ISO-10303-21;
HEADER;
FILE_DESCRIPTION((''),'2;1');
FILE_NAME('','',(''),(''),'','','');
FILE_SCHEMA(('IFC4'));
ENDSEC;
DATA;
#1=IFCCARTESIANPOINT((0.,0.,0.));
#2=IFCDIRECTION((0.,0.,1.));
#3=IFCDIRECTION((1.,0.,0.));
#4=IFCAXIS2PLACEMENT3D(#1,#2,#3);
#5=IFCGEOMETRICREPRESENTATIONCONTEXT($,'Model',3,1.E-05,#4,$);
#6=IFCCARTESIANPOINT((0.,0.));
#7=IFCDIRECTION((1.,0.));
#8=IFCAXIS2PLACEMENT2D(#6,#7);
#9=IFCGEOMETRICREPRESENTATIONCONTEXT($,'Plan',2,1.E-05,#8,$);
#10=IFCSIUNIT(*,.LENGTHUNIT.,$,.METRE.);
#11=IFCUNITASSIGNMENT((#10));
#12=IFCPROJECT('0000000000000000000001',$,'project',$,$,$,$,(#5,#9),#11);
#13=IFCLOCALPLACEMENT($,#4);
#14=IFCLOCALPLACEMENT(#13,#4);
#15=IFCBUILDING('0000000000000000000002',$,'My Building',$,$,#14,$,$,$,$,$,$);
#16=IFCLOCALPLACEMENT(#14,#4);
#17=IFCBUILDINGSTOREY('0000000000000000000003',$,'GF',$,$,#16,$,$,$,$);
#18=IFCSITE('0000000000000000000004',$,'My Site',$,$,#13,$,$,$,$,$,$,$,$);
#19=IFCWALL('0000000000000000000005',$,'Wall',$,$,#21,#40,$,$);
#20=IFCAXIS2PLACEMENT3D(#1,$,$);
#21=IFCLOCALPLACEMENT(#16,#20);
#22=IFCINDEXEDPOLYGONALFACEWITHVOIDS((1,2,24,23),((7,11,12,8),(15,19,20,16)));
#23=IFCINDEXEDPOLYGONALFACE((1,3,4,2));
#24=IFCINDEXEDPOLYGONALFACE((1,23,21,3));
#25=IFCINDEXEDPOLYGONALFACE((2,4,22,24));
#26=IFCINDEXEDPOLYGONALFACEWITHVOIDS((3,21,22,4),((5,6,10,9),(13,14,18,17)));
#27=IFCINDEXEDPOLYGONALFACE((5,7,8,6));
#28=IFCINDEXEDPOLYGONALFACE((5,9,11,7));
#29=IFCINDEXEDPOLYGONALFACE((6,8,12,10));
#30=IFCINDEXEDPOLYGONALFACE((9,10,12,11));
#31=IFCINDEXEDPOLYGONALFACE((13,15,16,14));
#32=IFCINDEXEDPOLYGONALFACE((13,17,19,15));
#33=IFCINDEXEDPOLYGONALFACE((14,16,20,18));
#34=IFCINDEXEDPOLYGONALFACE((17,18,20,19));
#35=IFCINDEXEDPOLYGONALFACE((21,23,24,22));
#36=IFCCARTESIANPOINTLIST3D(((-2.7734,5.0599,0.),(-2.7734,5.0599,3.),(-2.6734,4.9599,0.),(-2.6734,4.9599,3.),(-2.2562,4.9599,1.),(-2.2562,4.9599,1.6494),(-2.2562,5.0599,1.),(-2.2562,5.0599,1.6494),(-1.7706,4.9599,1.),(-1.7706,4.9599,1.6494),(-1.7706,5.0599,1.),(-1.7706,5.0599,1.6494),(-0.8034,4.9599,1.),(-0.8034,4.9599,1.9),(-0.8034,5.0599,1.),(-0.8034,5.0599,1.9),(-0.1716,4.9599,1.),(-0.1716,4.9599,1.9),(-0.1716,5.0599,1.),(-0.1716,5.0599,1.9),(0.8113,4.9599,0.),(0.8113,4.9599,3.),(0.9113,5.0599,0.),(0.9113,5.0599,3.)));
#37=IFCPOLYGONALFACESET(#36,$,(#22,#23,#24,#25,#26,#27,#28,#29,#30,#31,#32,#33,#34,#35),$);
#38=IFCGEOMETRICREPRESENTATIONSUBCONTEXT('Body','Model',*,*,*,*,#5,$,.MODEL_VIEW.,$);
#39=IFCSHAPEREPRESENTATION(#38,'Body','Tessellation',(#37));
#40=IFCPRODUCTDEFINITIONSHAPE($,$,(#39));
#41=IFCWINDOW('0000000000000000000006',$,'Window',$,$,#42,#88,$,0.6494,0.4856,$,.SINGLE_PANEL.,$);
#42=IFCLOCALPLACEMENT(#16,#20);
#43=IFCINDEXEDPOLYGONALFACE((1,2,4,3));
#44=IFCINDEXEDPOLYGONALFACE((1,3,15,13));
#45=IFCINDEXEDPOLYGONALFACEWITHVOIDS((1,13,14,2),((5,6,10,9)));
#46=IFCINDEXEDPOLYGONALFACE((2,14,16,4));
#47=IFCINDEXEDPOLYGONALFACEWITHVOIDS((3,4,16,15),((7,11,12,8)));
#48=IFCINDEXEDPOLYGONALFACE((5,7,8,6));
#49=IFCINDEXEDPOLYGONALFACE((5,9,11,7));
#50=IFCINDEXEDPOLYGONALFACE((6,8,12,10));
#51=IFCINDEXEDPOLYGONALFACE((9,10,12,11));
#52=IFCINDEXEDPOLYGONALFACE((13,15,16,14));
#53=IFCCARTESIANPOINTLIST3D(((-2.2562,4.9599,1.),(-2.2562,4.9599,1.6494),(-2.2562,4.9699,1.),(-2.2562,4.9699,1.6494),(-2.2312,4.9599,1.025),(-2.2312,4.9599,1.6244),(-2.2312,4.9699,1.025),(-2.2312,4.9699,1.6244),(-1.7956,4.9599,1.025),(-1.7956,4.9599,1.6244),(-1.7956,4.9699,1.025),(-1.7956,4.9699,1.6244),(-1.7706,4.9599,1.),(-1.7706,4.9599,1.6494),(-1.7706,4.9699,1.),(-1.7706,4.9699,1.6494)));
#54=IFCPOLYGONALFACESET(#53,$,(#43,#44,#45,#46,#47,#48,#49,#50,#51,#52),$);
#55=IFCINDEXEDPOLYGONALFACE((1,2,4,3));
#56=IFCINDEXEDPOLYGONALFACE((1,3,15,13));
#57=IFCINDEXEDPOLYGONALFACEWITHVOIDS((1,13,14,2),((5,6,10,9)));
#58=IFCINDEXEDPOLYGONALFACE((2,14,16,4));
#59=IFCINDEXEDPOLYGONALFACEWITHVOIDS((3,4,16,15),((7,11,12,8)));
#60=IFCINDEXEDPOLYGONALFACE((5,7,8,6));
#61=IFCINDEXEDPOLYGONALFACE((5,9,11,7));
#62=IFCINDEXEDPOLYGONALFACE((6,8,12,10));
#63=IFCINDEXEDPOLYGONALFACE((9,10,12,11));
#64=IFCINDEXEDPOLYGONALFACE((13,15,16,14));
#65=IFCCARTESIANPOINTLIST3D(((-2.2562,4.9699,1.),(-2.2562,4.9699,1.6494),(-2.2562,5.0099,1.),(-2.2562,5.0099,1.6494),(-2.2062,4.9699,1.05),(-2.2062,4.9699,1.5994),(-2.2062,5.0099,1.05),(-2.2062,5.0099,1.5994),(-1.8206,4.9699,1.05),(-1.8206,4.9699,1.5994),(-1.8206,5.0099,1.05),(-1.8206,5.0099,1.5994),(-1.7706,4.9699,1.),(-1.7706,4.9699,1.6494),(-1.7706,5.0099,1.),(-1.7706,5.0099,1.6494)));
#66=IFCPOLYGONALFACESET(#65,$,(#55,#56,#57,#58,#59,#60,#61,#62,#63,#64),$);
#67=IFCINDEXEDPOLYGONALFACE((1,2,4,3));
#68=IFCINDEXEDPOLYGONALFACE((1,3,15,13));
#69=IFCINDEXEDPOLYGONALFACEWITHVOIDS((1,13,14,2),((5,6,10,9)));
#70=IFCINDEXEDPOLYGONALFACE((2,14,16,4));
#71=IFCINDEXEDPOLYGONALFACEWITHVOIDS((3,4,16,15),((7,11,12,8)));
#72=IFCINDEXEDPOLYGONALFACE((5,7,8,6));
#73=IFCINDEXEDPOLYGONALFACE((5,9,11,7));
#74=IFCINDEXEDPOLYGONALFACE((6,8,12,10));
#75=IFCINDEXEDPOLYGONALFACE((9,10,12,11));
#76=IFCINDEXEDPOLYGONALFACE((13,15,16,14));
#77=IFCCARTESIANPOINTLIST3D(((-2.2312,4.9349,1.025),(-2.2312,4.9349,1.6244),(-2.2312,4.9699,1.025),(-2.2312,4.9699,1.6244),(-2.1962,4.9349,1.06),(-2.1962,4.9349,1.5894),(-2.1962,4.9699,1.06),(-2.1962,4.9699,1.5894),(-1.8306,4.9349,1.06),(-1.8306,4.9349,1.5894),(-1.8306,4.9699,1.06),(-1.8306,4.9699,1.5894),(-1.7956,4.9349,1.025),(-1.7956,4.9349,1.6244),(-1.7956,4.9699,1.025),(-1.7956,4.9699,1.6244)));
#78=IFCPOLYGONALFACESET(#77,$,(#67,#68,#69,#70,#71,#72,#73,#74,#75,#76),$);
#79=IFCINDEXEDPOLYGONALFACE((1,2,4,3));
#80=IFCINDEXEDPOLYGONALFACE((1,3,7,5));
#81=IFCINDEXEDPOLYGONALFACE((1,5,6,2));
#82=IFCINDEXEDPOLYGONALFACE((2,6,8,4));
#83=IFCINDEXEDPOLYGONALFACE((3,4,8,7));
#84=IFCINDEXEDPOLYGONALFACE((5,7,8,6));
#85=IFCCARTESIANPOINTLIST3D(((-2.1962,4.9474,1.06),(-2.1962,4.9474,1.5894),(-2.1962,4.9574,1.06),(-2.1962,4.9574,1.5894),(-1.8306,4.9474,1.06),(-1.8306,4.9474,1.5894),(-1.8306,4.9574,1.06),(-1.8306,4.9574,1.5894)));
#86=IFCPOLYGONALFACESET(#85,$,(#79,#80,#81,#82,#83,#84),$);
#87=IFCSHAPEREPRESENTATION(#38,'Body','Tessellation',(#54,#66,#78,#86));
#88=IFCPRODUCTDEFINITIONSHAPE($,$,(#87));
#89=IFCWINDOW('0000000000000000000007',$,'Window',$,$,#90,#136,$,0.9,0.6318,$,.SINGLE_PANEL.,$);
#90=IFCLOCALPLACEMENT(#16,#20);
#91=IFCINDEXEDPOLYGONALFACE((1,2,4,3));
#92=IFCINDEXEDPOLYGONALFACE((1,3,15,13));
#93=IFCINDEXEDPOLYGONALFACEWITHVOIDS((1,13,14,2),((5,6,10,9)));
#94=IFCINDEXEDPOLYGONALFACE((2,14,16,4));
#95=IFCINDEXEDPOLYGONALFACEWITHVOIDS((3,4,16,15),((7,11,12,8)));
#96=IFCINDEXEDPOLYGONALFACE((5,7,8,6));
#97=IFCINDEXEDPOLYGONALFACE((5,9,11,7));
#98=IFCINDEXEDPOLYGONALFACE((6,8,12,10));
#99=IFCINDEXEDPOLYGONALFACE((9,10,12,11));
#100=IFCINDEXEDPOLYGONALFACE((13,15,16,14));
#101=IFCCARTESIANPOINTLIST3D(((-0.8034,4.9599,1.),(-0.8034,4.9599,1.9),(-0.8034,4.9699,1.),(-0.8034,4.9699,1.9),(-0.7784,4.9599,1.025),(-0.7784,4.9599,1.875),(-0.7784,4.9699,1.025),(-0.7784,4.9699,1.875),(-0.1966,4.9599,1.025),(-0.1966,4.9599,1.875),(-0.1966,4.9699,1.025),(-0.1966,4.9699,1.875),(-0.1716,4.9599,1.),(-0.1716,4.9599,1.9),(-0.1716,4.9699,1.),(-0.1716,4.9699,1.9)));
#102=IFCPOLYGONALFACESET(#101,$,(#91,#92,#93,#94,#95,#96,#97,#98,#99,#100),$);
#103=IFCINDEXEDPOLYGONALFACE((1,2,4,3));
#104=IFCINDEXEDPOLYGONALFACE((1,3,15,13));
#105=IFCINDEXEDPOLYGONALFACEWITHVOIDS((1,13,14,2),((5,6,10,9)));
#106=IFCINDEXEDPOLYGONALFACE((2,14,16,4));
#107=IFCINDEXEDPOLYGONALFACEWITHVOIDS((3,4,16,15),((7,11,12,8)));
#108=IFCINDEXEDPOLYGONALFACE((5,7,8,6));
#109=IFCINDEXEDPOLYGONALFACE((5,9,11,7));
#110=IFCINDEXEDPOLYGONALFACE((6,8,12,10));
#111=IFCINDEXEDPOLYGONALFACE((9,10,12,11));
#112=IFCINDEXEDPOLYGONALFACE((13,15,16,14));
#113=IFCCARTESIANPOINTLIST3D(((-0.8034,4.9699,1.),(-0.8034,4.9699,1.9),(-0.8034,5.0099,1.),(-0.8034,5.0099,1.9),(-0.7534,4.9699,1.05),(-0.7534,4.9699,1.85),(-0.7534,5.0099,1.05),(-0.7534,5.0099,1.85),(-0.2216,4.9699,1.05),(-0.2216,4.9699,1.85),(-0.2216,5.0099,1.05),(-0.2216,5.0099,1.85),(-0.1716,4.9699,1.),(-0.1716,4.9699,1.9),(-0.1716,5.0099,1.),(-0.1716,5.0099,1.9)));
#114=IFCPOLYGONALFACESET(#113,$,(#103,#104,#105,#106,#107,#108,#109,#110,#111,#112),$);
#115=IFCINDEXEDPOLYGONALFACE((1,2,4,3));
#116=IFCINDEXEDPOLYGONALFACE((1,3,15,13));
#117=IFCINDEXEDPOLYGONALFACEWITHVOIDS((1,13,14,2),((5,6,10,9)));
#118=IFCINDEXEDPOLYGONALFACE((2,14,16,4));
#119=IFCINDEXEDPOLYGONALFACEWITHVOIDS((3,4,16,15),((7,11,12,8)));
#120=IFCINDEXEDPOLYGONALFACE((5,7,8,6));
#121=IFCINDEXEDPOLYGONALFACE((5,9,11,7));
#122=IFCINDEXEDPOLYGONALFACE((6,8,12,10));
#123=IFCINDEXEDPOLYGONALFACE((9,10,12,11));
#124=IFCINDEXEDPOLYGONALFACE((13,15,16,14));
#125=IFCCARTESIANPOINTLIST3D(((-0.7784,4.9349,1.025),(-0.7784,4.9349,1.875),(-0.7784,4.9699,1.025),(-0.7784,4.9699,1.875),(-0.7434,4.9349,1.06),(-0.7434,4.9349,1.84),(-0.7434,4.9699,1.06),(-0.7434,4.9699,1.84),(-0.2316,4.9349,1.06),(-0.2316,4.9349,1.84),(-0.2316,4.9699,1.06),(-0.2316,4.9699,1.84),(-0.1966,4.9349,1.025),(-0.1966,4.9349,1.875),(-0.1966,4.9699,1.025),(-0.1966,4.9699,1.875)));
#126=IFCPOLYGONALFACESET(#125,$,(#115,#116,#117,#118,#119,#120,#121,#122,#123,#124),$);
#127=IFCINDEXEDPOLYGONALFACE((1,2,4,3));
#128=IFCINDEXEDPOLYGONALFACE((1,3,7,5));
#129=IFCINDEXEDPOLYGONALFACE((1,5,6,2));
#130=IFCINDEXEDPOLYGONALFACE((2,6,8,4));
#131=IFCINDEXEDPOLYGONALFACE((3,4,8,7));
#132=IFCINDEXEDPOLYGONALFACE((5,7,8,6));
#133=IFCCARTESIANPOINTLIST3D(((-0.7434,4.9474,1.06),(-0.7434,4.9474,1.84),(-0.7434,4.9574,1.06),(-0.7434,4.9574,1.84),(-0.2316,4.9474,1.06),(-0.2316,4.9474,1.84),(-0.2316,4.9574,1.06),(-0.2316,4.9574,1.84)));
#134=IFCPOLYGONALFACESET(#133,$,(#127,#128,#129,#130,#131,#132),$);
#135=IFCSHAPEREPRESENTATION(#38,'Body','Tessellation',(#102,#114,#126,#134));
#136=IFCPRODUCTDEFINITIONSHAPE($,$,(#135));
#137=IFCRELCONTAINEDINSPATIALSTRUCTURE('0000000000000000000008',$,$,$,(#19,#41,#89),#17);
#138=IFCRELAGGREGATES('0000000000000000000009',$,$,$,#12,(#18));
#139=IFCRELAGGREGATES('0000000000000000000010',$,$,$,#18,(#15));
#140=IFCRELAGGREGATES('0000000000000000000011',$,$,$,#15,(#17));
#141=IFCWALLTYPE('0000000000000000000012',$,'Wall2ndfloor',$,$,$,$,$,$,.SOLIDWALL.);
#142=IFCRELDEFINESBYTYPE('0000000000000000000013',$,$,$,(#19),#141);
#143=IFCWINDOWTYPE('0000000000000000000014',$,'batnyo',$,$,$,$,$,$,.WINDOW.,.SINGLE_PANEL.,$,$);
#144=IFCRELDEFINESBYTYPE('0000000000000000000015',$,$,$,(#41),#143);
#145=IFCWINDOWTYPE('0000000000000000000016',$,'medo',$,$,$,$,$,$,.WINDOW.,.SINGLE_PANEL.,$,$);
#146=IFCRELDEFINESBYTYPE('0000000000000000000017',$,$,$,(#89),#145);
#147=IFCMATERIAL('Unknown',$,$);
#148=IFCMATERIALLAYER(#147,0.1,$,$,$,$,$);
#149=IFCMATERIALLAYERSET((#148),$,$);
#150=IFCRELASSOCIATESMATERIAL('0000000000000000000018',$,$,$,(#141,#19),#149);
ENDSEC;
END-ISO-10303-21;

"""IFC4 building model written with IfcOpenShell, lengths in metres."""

from ifc_helpers import new_model, entity, si_unit, frame, origin_with_axes, origin_2d_with_axis, place, context, subcontext, project, spatial, line, indexed_curve, outline, extrude, shape, source, transform, mapped, material, layer, layer_set, layer_usage, type_object, type_shapes, element, fill, save


model = new_model("IFC4")

# Units and contexts
model_context = context("Model", 3, precision=1e-05, world=origin_with_axes())
plan_context = context("Plan", 2, precision=1e-05, world=origin_2d_with_axis())
body_context_1 = subcontext(model_context, "Body", "Model", "MODEL_VIEW")
body_context_2 = subcontext(plan_context, "Body", "Plan", "PLAN_VIEW")
ifc_project = project(units=[si_unit("LENGTHUNIT", "METRE")], contexts=[model_context, plan_context])

# Site, building, storey
site_placement = place(None, origin_with_axes())
site = spatial("IfcSite", under=ifc_project, at=site_placement, Name="My Site")
building_placement = place(site_placement, origin_with_axes())
building = spatial("IfcBuilding", under=site, at=building_placement, Name="My Building")
storey_placement = place(building_placement, origin_with_axes())
storey = spatial("IfcBuildingStorey", under=building, at=storey_placement, Name="GF")

# Shared definitions
ifc_material = material(Name="Unknown")

# Shared definitions
ifc_layer = layer(ifc_material, 0.1)
ifc_layer_set = layer_set([ifc_layer])
wall_type = type_object("IfcWallType", Name="Wall2ndfloor", PredefinedType="SOLIDWALL", material=ifc_layer_set)

# Wall, openings, windows
ifc_layer_usage_1 = layer_usage(ifc_layer_set, "AXIS2", "POSITIVE", 0.0)
wall_1_placement = place(storey_placement, frame((0.9113, 5.0599, 0.0), z_axis=(0.0, 0.0, 1.0), x_axis=(-1.0, 0.0, 0.0)))
wall_1 = element("IfcWall", 1, at=wall_1_placement, inside=storey, type_object=wall_type, material=ifc_layer_usage_1, Name="Wall", context=body_context_1, shape_type="SweptSolid", body=[
    extrude(outline(indexed_curve([(0.0, 0.0), (0.1, 0.1), (3.5847, 0.1), (3.6847, 0.0)], segments=[line(1, 2, 3, 4, 1)])), origin_with_axes(), (0.0, 0.0, 1.0), 3.0),
])
shared_shape_1 = source(origin_with_axes(), body_context_1, "Body", "SweptSolid", [
    extrude(outline(indexed_curve([(0.0, 0.0), (0.4856, 0.0), (0.4856, 0.6494), (0.0, 0.6494)], segments=[line(1, 2, 3, 4, 1)])), frame((0.0, -0.6, 0.0), z_axis=(0.0, -1.0, 0.0), x_axis=(1.0, 0.0, 0.0)), (0.0, 0.0, -1.0), 1.2),
])
opening_1_placement = place(wall_1_placement, frame((2.6819, 0.0, 1.0), z_axis=(0.0, 0.0, 1.0), x_axis=(1.0, 0.0, 0.0)))
opening_1 = element("IfcOpeningElement", 2, at=opening_1_placement, cuts=wall_1, PredefinedType="OPENING", context=body_context_1, shape_type="MappedRepresentation", body=[
    mapped(shared_shape_1, transform((0.0, 0.0, 0.0), x_axis=(1.0, 0.0, 0.0), y_axis=(0.0, 1.0, 0.0), z_axis=(0.0, 0.0, 1.0), scale=1.0)),
])
shared_shape_2 = source(origin_with_axes(), body_context_1, "Body", "SweptSolid", [
    extrude(outline(indexed_curve([(0.0, 0.0), (0.6318, 0.0), (0.6318, 0.9), (0.0, 0.9)], segments=[line(1, 2, 3, 4, 1)])), frame((0.0, -0.6, 0.0), z_axis=(0.0, -1.0, 0.0), x_axis=(1.0, 0.0, 0.0)), (0.0, 0.0, -1.0), 1.2),
])
opening_2_placement = place(wall_1_placement, frame((1.083, 0.0, 1.0), z_axis=(0.0, 0.0, 1.0), x_axis=(1.0, 0.0, 0.0)))
opening_2 = element("IfcOpeningElement", 3, at=opening_2_placement, cuts=wall_1, PredefinedType="OPENING", context=body_context_1, shape_type="MappedRepresentation", body=[
    mapped(shared_shape_2, transform((0.0, 0.0, 0.0), x_axis=(1.0, 0.0, 0.0), y_axis=(0.0, 1.0, 0.0), z_axis=(0.0, 0.0, 1.0), scale=1.0)),
])
window_type_1 = type_object("IfcWindowType", Name="batnyo", PartitioningType="SINGLE_PANEL", PredefinedType="WINDOW")
shared_shape_3 = source(origin_with_axes(), body_context_1, "Body", "SweptSolid", [
    extrude(outline(indexed_curve([(0.0, 0.0), (0.4856, 0.0), (0.4856, 0.6494), (0.0, 0.6494)], segments=[line(1, 2, 3, 4, 1)]), holes=[indexed_curve([(0.025, 0.025), (0.4606, 0.025), (0.4606, 0.6244), (0.025, 0.6244)], segments=[line(1, 2, 3, 4, 1)])]), frame((0.0, 0.09, 0.0), z_axis=(0.0, -1.0, 0.0), x_axis=(1.0, 0.0, 0.0)), (0.0, 0.0, -1.0), 0.01),
    extrude(outline(indexed_curve([(0.0, 0.0), (0.4856, 0.0), (0.4856, 0.6494), (0.0, 0.6494)], segments=[line(1, 2, 3, 4, 1)]), holes=[indexed_curve([(0.05, 0.05), (0.4356, 0.05), (0.4356, 0.5994), (0.05, 0.5994)], segments=[line(1, 2, 3, 4, 1)])]), frame((0.0, 0.05, 0.0), z_axis=(0.0, -1.0, 0.0), x_axis=(1.0, 0.0, 0.0)), (0.0, 0.0, -1.0), 0.04),
    extrude(outline(indexed_curve([(0.0, 0.0), (0.4356, 0.0), (0.4356, 0.5994), (0.0, 0.5994)], segments=[line(1, 2, 3, 4, 1)]), holes=[indexed_curve([(0.035, 0.035), (0.4006, 0.035), (0.4006, 0.5644), (0.035, 0.5644)], segments=[line(1, 2, 3, 4, 1)])]), frame((0.025, 0.09, 0.025), z_axis=(0.0, -1.0, 0.0), x_axis=(1.0, 0.0, 0.0)), (0.0, 0.0, -1.0), 0.035),
    extrude(outline(indexed_curve([(0.035, 0.035), (0.4006, 0.035), (0.4006, 0.5644), (0.035, 0.5644)], segments=[line(1, 2, 3, 4, 1)])), frame((0.025, 0.1025, 0.025), z_axis=(0.0, -1.0, 0.0), x_axis=(1.0, 0.0, 0.0)), (0.0, 0.0, -1.0), 0.01),
])
shared_shape_4 = source(origin_with_axes(), body_context_2, "Body", "Curve2D", [
    entity("IfcIndexedPolyCurve", entity("IfcCartesianPointList2D", [[0.05, 0.05], [0.4356, 0.05]])),
    entity("IfcIndexedPolyCurve", entity("IfcCartesianPointList2D", [[0.0, 0.1], [0.025, 0.1], [0.025, 0.09], [0.05, 0.09], [0.05, 0.05], [0.0, 0.05]]), [entity("IfcLineIndex", [1, 2, 3, 4, 5, 6, 1])]),
    entity("IfcIndexedPolyCurve", entity("IfcCartesianPointList2D", [[0.4856, 0.1], [0.4606, 0.1], [0.4606, 0.09], [0.4356, 0.09], [0.4356, 0.05], [0.4856, 0.05]]), [entity("IfcLineIndex", [1, 2, 3, 4, 5, 6, 1])]),
    entity("IfcIndexedPolyCurve", entity("IfcCartesianPointList2D", [[0.025, 0.09], [0.06, 0.09], [0.06, 0.125], [0.025, 0.125]]), [entity("IfcLineIndex", [1, 2, 3, 4, 1])]),
    entity("IfcIndexedPolyCurve", entity("IfcCartesianPointList2D", [[0.4606, 0.09], [0.4256, 0.09], [0.4256, 0.125], [0.4606, 0.125]]), [entity("IfcLineIndex", [1, 2, 3, 4, 1])]),
    entity("IfcIndexedPolyCurve", entity("IfcCartesianPointList2D", [[0.06, 0.09], [0.4256, 0.09]])),
    entity("IfcIndexedPolyCurve", entity("IfcCartesianPointList2D", [[0.06, 0.125], [0.4256, 0.125]])),
    entity("IfcIndexedPolyCurve", entity("IfcCartesianPointList2D", [[0.06, 0.1075], [0.4256, 0.1075]])),
])
type_shapes(window_type_1, [shared_shape_3, shared_shape_4])
window_1_placement = place(opening_1_placement, frame((0.0, 0.0, 0.0), z_axis=(0.0, 0.0, 1.0), x_axis=(1.0, 0.0, 0.0)))
window_1 = element("IfcWindow", 4, at=window_1_placement, inside=storey, type_object=window_type_1, Name="Window", OverallHeight=0.6494, OverallWidth=0.4856, PartitioningType="SINGLE_PANEL", shapes=[
    shape(body_context_1, "Body", "MappedRepresentation", [mapped(shared_shape_3, transform((0.0, 0.0, 0.0), x_axis=(1.0, 0.0, 0.0), y_axis=(0.0, 1.0, 0.0), z_axis=(0.0, 0.0, 1.0), scale=1.0))]),
    shape(body_context_2, "Body", "MappedRepresentation", [mapped(shared_shape_4, transform((0.0, 0.0, 0.0), x_axis=(1.0, 0.0, 0.0), y_axis=(0.0, 1.0, 0.0), z_axis=(0.0, 0.0, 1.0), scale=1.0))]),
])
fill(opening_1, window_1)
window_type_2 = type_object("IfcWindowType", Name="medo", PartitioningType="SINGLE_PANEL", PredefinedType="WINDOW")
shared_shape_5 = source(origin_with_axes(), body_context_1, "Body", "SweptSolid", [
    extrude(outline(indexed_curve([(0.0, 0.0), (0.6318, 0.0), (0.6318, 0.9), (0.0, 0.9)], segments=[line(1, 2, 3, 4, 1)]), holes=[indexed_curve([(0.025, 0.025), (0.6068, 0.025), (0.6068, 0.875), (0.025, 0.875)], segments=[line(1, 2, 3, 4, 1)])]), frame((0.0, 0.09, 0.0), z_axis=(0.0, -1.0, 0.0), x_axis=(1.0, 0.0, 0.0)), (0.0, 0.0, -1.0), 0.01),
    extrude(outline(indexed_curve([(0.0, 0.0), (0.6318, 0.0), (0.6318, 0.9), (0.0, 0.9)], segments=[line(1, 2, 3, 4, 1)]), holes=[indexed_curve([(0.05, 0.05), (0.5818, 0.05), (0.5818, 0.85), (0.05, 0.85)], segments=[line(1, 2, 3, 4, 1)])]), frame((0.0, 0.05, 0.0), z_axis=(0.0, -1.0, 0.0), x_axis=(1.0, 0.0, 0.0)), (0.0, 0.0, -1.0), 0.04),
    extrude(outline(indexed_curve([(0.0, 0.0), (0.5818, 0.0), (0.5818, 0.85), (0.0, 0.85)], segments=[line(1, 2, 3, 4, 1)]), holes=[indexed_curve([(0.035, 0.035), (0.5468, 0.035), (0.5468, 0.815), (0.035, 0.815)], segments=[line(1, 2, 3, 4, 1)])]), frame((0.025, 0.09, 0.025), z_axis=(0.0, -1.0, 0.0), x_axis=(1.0, 0.0, 0.0)), (0.0, 0.0, -1.0), 0.035),
    extrude(outline(indexed_curve([(0.035, 0.035), (0.5468, 0.035), (0.5468, 0.815), (0.035, 0.815)], segments=[line(1, 2, 3, 4, 1)])), frame((0.025, 0.1025, 0.025), z_axis=(0.0, -1.0, 0.0), x_axis=(1.0, 0.0, 0.0)), (0.0, 0.0, -1.0), 0.01),
])
shared_shape_6 = source(origin_with_axes(), body_context_2, "Body", "Curve2D", [
    entity("IfcIndexedPolyCurve", entity("IfcCartesianPointList2D", [[0.05, 0.05], [0.5818, 0.05]])),
    entity("IfcIndexedPolyCurve", entity("IfcCartesianPointList2D", [[0.0, 0.1], [0.025, 0.1], [0.025, 0.09], [0.05, 0.09], [0.05, 0.05], [0.0, 0.05]]), [entity("IfcLineIndex", [1, 2, 3, 4, 5, 6, 1])]),
    entity("IfcIndexedPolyCurve", entity("IfcCartesianPointList2D", [[0.6318, 0.1], [0.6068, 0.1], [0.6068, 0.09], [0.5818, 0.09], [0.5818, 0.05], [0.6318, 0.05]]), [entity("IfcLineIndex", [1, 2, 3, 4, 5, 6, 1])]),
    entity("IfcIndexedPolyCurve", entity("IfcCartesianPointList2D", [[0.025, 0.09], [0.06, 0.09], [0.06, 0.125], [0.025, 0.125]]), [entity("IfcLineIndex", [1, 2, 3, 4, 1])]),
    entity("IfcIndexedPolyCurve", entity("IfcCartesianPointList2D", [[0.6068, 0.09], [0.5718, 0.09], [0.5718, 0.125], [0.6068, 0.125]]), [entity("IfcLineIndex", [1, 2, 3, 4, 1])]),
    entity("IfcIndexedPolyCurve", entity("IfcCartesianPointList2D", [[0.06, 0.09], [0.5718, 0.09]])),
    entity("IfcIndexedPolyCurve", entity("IfcCartesianPointList2D", [[0.06, 0.125], [0.5718, 0.125]])),
    entity("IfcIndexedPolyCurve", entity("IfcCartesianPointList2D", [[0.06, 0.1075], [0.5718, 0.1075]])),
])
type_shapes(window_type_2, [shared_shape_5, shared_shape_6])
window_2_placement = place(opening_2_placement, frame((0.0, 0.0, 0.0), z_axis=(0.0, 0.0, 1.0), x_axis=(1.0, 0.0, 0.0)))
window_2 = element("IfcWindow", 5, at=window_2_placement, inside=storey, type_object=window_type_2, Name="Window", OverallHeight=0.9, OverallWidth=0.6318, PartitioningType="SINGLE_PANEL", shapes=[
    shape(body_context_1, "Body", "MappedRepresentation", [mapped(shared_shape_5, transform((0.0, 0.0, 0.0), x_axis=(1.0, 0.0, 0.0), y_axis=(0.0, 1.0, 0.0), z_axis=(0.0, 0.0, 1.0), scale=1.0))]),
    shape(body_context_2, "Body", "MappedRepresentation", [mapped(shared_shape_6, transform((0.0, 0.0, 0.0), x_axis=(1.0, 0.0, 0.0), y_axis=(0.0, 1.0, 0.0), z_axis=(0.0, 0.0, 1.0), scale=1.0))]),
])
fill(opening_2, window_2)

save(model, "model.ifc")
